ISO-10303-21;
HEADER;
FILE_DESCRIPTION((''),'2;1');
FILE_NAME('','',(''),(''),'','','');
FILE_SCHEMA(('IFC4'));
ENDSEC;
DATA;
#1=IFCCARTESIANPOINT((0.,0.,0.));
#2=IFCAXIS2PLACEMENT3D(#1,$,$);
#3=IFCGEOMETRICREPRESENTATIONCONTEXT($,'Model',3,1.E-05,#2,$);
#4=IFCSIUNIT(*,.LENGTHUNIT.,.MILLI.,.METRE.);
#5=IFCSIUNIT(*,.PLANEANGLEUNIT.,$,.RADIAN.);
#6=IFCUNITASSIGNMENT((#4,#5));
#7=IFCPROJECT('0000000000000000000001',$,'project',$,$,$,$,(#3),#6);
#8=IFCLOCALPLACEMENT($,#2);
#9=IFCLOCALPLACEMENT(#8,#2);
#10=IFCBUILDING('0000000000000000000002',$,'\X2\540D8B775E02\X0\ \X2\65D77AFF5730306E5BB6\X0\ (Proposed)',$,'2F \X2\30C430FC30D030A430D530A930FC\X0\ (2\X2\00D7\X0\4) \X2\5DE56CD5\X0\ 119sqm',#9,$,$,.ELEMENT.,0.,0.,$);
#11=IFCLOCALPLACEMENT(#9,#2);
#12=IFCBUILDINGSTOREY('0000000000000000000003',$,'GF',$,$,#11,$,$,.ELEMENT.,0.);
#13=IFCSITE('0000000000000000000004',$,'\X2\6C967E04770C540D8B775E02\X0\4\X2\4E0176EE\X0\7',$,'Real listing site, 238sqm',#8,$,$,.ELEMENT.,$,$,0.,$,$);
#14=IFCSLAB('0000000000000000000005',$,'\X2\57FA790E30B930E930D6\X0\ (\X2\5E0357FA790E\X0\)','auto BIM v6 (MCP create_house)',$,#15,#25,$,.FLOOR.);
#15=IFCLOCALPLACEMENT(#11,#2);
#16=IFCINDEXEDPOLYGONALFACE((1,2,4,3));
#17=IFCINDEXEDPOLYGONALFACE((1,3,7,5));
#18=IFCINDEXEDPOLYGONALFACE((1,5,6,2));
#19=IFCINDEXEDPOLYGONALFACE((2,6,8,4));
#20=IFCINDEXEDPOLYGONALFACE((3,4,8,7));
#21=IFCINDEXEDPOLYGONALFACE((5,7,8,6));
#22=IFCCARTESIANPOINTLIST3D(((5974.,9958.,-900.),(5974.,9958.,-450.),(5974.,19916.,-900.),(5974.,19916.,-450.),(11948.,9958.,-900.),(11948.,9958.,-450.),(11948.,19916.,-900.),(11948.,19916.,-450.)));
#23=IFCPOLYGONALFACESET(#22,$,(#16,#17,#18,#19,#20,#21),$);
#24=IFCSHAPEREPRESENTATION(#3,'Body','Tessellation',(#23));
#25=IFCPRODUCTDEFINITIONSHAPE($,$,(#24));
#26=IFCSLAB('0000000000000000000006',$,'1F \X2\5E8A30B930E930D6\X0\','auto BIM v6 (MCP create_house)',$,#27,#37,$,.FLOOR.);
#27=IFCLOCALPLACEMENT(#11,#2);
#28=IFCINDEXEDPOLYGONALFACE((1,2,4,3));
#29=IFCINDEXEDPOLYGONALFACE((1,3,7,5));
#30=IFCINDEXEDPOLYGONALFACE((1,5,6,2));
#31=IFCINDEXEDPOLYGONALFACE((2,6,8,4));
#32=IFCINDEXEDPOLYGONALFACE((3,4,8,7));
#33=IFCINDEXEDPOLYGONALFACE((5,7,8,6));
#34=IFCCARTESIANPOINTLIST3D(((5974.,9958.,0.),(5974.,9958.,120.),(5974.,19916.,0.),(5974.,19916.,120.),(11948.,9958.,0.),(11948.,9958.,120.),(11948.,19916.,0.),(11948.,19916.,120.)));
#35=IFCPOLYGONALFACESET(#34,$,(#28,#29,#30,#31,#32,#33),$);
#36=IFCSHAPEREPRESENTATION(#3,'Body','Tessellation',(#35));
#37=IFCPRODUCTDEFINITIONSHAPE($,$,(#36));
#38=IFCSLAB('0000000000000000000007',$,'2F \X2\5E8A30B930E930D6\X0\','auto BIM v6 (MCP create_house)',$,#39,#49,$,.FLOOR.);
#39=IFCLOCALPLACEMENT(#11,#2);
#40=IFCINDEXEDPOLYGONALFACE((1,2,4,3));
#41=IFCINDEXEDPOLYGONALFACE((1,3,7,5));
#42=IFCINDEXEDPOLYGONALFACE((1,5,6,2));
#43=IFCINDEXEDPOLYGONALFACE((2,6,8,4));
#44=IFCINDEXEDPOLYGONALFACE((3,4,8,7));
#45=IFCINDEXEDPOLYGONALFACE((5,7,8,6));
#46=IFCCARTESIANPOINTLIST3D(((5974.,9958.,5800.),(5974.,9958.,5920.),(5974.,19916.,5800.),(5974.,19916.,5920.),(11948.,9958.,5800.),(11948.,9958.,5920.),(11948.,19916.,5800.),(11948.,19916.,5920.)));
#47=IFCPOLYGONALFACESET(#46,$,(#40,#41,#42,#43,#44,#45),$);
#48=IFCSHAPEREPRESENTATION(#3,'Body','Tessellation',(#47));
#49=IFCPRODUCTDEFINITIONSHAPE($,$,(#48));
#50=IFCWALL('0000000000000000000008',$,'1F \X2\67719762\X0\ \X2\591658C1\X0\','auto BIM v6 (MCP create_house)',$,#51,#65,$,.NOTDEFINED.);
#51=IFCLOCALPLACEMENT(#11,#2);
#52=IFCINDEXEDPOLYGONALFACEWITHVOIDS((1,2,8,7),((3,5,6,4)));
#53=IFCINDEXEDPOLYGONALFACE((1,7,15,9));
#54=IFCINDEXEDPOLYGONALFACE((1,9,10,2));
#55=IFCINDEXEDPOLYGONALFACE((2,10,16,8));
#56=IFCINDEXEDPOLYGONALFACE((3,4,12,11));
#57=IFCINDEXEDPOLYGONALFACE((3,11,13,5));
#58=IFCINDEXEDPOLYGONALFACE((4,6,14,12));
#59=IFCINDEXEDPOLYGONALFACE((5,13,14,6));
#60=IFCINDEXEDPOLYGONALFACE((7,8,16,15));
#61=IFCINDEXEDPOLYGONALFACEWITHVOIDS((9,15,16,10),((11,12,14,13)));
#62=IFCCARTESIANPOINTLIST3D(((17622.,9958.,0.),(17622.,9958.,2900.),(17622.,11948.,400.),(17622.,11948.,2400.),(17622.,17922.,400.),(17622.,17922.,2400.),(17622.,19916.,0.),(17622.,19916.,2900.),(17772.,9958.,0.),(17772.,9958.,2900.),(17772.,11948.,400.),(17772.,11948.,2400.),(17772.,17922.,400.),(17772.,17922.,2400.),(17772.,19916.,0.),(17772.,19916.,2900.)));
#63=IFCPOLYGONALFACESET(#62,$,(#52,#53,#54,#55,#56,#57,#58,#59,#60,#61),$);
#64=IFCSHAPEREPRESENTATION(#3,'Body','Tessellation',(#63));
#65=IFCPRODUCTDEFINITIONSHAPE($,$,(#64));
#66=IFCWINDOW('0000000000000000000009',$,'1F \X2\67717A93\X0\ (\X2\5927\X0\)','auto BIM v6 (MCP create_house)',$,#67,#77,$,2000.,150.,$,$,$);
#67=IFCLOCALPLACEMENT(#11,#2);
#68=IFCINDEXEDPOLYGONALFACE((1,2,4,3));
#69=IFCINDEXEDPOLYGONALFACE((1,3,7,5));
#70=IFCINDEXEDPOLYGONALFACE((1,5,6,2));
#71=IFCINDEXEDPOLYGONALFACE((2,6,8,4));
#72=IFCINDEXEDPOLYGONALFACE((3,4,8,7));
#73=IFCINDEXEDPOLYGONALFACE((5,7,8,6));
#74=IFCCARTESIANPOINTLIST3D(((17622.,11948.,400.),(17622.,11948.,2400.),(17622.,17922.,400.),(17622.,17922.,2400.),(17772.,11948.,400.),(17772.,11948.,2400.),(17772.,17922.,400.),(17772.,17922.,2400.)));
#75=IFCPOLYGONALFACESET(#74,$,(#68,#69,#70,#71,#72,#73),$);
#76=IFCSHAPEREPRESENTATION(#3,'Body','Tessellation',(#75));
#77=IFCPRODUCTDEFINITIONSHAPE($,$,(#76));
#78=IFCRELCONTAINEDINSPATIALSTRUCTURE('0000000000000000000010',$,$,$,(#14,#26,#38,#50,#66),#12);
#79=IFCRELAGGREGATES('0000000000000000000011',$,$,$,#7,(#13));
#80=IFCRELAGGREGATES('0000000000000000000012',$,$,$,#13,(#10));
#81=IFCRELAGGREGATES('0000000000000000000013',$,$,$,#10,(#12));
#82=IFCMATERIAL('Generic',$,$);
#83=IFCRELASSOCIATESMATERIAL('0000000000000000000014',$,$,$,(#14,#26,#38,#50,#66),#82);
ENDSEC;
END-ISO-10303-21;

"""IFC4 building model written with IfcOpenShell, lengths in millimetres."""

from ifc_helpers import new_model, si_unit, frame, frame_2d, origin, place, context, project, spatial, rectangle, extrude, material, element, fill, save


model = new_model("IFC4")

# Units and contexts
model_context = context("Model", 3, precision=1e-05, world=origin())
ifc_project = project(units=[si_unit("LENGTHUNIT", "METRE", prefix="MILLI"), si_unit("PLANEANGLEUNIT", "RADIAN")], contexts=[model_context])

# Site, building, storey
site_placement = place(None, origin())
site = spatial("IfcSite", under=ifc_project, at=site_placement, Name="沖縄県名護市4丁目7", ObjectType="Real listing site, 238sqm", CompositionType="ELEMENT", RefElevation=0.0)
building_placement = place(site_placement, origin())
building = spatial("IfcBuilding", under=site, at=building_placement, Name="名護市 旗竿地の家 (Proposed)", ObjectType="2F ツーバイフォー (2×4) 工法 119sqm", CompositionType="ELEMENT", ElevationOfRefHeight=0.0, ElevationOfTerrain=0.0)
storey_placement = place(building_placement, origin())
storey = spatial("IfcBuildingStorey", under=building, at=storey_placement, Name="GF", CompositionType="ELEMENT", Elevation=0.0)

# Slabs
ifc_material = material(Name="Generic")
slab_1_placement = place(storey_placement, frame((2987.0, 4979.0, -450.0)))
element("IfcSlab", 1, at=slab_1_placement, inside=storey, material=ifc_material, Name="基礎スラブ (布基礎)", Description="auto BIM v6 (MCP create_house)", PredefinedType="FLOOR", context=model_context, shape_type="SweptSolid", body=[
    extrude(rectangle(XDim=5974.0, YDim=9958.0, at=frame_2d((2987.0, 4979.0))), frame((2987.0, 4979.0, -450.0)), (0.0, 0.0, 1.0), 450.0),
])
slab_2_placement = place(storey_placement, frame((2987.0, 4979.0, 0.0)))
element("IfcSlab", 2, at=slab_2_placement, inside=storey, material=ifc_material, Name="1F 床スラブ", Description="auto BIM v6 (MCP create_house)", PredefinedType="FLOOR", context=model_context, shape_type="SweptSolid", body=[
    extrude(rectangle(XDim=5974.0, YDim=9958.0, at=frame_2d((2987.0, 4979.0))), frame((2987.0, 4979.0, 0.0)), (0.0, 0.0, 1.0), 120.0),
])
slab_3_placement = place(storey_placement, frame((2987.0, 4979.0, 2900.0)))
element("IfcSlab", 3, at=slab_3_placement, inside=storey, material=ifc_material, Name="2F 床スラブ", Description="auto BIM v6 (MCP create_house)", PredefinedType="FLOOR", context=model_context, shape_type="SweptSolid", body=[
    extrude(rectangle(XDim=5974.0, YDim=9958.0, at=frame_2d((2987.0, 4979.0))), frame((2987.0, 4979.0, 2900.0)), (0.0, 0.0, 1.0), 120.0),
])

# Wall, opening, window
wall_1_placement = place(storey_placement, frame((8811.0, 4979.0, 0.0)))
wall_1 = element("IfcWall", 4, at=wall_1_placement, inside=storey, material=ifc_material, Name="1F 東面 外壁", Description="auto BIM v6 (MCP create_house)", PredefinedType="NOTDEFINED", context=model_context, shape_type="SweptSolid", body=[
    extrude(rectangle(XDim=150.0, YDim=9958.0, at=frame_2d((75.0, 4979.0))), frame((8811.0, 4979.0, 0.0)), (0.0, 0.0, 1.0), 2900.0),
])
opening_1_placement = place(storey_placement, frame((8811.0, 5974.0, 200.0)))
opening_1 = element("IfcOpeningElement", 5, at=opening_1_placement, cuts=wall_1, PredefinedType="NOTDEFINED", context=model_context, shape_type="SweptSolid", body=[
    extrude(rectangle(XDim=150.0, YDim=5974.0, at=frame_2d((75.0, 2987.0))), frame((8811.0, 5974.0, 200.0)), (0.0, 0.0, 1.0), 2000.0),
])
window_1_placement = place(storey_placement, frame((8811.0, 5974.0, 200.0)))
window_1 = element("IfcWindow", 6, at=window_1_placement, inside=storey, material=ifc_material, Name="1F 東窓 (大)", Description="auto BIM v6 (MCP create_house)", OverallHeight=2000.0, OverallWidth=150.0, context=model_context, shape_type="SweptSolid", body=[
    extrude(rectangle(XDim=150.0, YDim=5974.0, at=frame_2d((75.0, 2987.0))), frame((8811.0, 5974.0, 200.0)), (0.0, 0.0, 1.0), 2000.0),
])
fill(opening_1, window_1)

save(model, "model.ifc")
